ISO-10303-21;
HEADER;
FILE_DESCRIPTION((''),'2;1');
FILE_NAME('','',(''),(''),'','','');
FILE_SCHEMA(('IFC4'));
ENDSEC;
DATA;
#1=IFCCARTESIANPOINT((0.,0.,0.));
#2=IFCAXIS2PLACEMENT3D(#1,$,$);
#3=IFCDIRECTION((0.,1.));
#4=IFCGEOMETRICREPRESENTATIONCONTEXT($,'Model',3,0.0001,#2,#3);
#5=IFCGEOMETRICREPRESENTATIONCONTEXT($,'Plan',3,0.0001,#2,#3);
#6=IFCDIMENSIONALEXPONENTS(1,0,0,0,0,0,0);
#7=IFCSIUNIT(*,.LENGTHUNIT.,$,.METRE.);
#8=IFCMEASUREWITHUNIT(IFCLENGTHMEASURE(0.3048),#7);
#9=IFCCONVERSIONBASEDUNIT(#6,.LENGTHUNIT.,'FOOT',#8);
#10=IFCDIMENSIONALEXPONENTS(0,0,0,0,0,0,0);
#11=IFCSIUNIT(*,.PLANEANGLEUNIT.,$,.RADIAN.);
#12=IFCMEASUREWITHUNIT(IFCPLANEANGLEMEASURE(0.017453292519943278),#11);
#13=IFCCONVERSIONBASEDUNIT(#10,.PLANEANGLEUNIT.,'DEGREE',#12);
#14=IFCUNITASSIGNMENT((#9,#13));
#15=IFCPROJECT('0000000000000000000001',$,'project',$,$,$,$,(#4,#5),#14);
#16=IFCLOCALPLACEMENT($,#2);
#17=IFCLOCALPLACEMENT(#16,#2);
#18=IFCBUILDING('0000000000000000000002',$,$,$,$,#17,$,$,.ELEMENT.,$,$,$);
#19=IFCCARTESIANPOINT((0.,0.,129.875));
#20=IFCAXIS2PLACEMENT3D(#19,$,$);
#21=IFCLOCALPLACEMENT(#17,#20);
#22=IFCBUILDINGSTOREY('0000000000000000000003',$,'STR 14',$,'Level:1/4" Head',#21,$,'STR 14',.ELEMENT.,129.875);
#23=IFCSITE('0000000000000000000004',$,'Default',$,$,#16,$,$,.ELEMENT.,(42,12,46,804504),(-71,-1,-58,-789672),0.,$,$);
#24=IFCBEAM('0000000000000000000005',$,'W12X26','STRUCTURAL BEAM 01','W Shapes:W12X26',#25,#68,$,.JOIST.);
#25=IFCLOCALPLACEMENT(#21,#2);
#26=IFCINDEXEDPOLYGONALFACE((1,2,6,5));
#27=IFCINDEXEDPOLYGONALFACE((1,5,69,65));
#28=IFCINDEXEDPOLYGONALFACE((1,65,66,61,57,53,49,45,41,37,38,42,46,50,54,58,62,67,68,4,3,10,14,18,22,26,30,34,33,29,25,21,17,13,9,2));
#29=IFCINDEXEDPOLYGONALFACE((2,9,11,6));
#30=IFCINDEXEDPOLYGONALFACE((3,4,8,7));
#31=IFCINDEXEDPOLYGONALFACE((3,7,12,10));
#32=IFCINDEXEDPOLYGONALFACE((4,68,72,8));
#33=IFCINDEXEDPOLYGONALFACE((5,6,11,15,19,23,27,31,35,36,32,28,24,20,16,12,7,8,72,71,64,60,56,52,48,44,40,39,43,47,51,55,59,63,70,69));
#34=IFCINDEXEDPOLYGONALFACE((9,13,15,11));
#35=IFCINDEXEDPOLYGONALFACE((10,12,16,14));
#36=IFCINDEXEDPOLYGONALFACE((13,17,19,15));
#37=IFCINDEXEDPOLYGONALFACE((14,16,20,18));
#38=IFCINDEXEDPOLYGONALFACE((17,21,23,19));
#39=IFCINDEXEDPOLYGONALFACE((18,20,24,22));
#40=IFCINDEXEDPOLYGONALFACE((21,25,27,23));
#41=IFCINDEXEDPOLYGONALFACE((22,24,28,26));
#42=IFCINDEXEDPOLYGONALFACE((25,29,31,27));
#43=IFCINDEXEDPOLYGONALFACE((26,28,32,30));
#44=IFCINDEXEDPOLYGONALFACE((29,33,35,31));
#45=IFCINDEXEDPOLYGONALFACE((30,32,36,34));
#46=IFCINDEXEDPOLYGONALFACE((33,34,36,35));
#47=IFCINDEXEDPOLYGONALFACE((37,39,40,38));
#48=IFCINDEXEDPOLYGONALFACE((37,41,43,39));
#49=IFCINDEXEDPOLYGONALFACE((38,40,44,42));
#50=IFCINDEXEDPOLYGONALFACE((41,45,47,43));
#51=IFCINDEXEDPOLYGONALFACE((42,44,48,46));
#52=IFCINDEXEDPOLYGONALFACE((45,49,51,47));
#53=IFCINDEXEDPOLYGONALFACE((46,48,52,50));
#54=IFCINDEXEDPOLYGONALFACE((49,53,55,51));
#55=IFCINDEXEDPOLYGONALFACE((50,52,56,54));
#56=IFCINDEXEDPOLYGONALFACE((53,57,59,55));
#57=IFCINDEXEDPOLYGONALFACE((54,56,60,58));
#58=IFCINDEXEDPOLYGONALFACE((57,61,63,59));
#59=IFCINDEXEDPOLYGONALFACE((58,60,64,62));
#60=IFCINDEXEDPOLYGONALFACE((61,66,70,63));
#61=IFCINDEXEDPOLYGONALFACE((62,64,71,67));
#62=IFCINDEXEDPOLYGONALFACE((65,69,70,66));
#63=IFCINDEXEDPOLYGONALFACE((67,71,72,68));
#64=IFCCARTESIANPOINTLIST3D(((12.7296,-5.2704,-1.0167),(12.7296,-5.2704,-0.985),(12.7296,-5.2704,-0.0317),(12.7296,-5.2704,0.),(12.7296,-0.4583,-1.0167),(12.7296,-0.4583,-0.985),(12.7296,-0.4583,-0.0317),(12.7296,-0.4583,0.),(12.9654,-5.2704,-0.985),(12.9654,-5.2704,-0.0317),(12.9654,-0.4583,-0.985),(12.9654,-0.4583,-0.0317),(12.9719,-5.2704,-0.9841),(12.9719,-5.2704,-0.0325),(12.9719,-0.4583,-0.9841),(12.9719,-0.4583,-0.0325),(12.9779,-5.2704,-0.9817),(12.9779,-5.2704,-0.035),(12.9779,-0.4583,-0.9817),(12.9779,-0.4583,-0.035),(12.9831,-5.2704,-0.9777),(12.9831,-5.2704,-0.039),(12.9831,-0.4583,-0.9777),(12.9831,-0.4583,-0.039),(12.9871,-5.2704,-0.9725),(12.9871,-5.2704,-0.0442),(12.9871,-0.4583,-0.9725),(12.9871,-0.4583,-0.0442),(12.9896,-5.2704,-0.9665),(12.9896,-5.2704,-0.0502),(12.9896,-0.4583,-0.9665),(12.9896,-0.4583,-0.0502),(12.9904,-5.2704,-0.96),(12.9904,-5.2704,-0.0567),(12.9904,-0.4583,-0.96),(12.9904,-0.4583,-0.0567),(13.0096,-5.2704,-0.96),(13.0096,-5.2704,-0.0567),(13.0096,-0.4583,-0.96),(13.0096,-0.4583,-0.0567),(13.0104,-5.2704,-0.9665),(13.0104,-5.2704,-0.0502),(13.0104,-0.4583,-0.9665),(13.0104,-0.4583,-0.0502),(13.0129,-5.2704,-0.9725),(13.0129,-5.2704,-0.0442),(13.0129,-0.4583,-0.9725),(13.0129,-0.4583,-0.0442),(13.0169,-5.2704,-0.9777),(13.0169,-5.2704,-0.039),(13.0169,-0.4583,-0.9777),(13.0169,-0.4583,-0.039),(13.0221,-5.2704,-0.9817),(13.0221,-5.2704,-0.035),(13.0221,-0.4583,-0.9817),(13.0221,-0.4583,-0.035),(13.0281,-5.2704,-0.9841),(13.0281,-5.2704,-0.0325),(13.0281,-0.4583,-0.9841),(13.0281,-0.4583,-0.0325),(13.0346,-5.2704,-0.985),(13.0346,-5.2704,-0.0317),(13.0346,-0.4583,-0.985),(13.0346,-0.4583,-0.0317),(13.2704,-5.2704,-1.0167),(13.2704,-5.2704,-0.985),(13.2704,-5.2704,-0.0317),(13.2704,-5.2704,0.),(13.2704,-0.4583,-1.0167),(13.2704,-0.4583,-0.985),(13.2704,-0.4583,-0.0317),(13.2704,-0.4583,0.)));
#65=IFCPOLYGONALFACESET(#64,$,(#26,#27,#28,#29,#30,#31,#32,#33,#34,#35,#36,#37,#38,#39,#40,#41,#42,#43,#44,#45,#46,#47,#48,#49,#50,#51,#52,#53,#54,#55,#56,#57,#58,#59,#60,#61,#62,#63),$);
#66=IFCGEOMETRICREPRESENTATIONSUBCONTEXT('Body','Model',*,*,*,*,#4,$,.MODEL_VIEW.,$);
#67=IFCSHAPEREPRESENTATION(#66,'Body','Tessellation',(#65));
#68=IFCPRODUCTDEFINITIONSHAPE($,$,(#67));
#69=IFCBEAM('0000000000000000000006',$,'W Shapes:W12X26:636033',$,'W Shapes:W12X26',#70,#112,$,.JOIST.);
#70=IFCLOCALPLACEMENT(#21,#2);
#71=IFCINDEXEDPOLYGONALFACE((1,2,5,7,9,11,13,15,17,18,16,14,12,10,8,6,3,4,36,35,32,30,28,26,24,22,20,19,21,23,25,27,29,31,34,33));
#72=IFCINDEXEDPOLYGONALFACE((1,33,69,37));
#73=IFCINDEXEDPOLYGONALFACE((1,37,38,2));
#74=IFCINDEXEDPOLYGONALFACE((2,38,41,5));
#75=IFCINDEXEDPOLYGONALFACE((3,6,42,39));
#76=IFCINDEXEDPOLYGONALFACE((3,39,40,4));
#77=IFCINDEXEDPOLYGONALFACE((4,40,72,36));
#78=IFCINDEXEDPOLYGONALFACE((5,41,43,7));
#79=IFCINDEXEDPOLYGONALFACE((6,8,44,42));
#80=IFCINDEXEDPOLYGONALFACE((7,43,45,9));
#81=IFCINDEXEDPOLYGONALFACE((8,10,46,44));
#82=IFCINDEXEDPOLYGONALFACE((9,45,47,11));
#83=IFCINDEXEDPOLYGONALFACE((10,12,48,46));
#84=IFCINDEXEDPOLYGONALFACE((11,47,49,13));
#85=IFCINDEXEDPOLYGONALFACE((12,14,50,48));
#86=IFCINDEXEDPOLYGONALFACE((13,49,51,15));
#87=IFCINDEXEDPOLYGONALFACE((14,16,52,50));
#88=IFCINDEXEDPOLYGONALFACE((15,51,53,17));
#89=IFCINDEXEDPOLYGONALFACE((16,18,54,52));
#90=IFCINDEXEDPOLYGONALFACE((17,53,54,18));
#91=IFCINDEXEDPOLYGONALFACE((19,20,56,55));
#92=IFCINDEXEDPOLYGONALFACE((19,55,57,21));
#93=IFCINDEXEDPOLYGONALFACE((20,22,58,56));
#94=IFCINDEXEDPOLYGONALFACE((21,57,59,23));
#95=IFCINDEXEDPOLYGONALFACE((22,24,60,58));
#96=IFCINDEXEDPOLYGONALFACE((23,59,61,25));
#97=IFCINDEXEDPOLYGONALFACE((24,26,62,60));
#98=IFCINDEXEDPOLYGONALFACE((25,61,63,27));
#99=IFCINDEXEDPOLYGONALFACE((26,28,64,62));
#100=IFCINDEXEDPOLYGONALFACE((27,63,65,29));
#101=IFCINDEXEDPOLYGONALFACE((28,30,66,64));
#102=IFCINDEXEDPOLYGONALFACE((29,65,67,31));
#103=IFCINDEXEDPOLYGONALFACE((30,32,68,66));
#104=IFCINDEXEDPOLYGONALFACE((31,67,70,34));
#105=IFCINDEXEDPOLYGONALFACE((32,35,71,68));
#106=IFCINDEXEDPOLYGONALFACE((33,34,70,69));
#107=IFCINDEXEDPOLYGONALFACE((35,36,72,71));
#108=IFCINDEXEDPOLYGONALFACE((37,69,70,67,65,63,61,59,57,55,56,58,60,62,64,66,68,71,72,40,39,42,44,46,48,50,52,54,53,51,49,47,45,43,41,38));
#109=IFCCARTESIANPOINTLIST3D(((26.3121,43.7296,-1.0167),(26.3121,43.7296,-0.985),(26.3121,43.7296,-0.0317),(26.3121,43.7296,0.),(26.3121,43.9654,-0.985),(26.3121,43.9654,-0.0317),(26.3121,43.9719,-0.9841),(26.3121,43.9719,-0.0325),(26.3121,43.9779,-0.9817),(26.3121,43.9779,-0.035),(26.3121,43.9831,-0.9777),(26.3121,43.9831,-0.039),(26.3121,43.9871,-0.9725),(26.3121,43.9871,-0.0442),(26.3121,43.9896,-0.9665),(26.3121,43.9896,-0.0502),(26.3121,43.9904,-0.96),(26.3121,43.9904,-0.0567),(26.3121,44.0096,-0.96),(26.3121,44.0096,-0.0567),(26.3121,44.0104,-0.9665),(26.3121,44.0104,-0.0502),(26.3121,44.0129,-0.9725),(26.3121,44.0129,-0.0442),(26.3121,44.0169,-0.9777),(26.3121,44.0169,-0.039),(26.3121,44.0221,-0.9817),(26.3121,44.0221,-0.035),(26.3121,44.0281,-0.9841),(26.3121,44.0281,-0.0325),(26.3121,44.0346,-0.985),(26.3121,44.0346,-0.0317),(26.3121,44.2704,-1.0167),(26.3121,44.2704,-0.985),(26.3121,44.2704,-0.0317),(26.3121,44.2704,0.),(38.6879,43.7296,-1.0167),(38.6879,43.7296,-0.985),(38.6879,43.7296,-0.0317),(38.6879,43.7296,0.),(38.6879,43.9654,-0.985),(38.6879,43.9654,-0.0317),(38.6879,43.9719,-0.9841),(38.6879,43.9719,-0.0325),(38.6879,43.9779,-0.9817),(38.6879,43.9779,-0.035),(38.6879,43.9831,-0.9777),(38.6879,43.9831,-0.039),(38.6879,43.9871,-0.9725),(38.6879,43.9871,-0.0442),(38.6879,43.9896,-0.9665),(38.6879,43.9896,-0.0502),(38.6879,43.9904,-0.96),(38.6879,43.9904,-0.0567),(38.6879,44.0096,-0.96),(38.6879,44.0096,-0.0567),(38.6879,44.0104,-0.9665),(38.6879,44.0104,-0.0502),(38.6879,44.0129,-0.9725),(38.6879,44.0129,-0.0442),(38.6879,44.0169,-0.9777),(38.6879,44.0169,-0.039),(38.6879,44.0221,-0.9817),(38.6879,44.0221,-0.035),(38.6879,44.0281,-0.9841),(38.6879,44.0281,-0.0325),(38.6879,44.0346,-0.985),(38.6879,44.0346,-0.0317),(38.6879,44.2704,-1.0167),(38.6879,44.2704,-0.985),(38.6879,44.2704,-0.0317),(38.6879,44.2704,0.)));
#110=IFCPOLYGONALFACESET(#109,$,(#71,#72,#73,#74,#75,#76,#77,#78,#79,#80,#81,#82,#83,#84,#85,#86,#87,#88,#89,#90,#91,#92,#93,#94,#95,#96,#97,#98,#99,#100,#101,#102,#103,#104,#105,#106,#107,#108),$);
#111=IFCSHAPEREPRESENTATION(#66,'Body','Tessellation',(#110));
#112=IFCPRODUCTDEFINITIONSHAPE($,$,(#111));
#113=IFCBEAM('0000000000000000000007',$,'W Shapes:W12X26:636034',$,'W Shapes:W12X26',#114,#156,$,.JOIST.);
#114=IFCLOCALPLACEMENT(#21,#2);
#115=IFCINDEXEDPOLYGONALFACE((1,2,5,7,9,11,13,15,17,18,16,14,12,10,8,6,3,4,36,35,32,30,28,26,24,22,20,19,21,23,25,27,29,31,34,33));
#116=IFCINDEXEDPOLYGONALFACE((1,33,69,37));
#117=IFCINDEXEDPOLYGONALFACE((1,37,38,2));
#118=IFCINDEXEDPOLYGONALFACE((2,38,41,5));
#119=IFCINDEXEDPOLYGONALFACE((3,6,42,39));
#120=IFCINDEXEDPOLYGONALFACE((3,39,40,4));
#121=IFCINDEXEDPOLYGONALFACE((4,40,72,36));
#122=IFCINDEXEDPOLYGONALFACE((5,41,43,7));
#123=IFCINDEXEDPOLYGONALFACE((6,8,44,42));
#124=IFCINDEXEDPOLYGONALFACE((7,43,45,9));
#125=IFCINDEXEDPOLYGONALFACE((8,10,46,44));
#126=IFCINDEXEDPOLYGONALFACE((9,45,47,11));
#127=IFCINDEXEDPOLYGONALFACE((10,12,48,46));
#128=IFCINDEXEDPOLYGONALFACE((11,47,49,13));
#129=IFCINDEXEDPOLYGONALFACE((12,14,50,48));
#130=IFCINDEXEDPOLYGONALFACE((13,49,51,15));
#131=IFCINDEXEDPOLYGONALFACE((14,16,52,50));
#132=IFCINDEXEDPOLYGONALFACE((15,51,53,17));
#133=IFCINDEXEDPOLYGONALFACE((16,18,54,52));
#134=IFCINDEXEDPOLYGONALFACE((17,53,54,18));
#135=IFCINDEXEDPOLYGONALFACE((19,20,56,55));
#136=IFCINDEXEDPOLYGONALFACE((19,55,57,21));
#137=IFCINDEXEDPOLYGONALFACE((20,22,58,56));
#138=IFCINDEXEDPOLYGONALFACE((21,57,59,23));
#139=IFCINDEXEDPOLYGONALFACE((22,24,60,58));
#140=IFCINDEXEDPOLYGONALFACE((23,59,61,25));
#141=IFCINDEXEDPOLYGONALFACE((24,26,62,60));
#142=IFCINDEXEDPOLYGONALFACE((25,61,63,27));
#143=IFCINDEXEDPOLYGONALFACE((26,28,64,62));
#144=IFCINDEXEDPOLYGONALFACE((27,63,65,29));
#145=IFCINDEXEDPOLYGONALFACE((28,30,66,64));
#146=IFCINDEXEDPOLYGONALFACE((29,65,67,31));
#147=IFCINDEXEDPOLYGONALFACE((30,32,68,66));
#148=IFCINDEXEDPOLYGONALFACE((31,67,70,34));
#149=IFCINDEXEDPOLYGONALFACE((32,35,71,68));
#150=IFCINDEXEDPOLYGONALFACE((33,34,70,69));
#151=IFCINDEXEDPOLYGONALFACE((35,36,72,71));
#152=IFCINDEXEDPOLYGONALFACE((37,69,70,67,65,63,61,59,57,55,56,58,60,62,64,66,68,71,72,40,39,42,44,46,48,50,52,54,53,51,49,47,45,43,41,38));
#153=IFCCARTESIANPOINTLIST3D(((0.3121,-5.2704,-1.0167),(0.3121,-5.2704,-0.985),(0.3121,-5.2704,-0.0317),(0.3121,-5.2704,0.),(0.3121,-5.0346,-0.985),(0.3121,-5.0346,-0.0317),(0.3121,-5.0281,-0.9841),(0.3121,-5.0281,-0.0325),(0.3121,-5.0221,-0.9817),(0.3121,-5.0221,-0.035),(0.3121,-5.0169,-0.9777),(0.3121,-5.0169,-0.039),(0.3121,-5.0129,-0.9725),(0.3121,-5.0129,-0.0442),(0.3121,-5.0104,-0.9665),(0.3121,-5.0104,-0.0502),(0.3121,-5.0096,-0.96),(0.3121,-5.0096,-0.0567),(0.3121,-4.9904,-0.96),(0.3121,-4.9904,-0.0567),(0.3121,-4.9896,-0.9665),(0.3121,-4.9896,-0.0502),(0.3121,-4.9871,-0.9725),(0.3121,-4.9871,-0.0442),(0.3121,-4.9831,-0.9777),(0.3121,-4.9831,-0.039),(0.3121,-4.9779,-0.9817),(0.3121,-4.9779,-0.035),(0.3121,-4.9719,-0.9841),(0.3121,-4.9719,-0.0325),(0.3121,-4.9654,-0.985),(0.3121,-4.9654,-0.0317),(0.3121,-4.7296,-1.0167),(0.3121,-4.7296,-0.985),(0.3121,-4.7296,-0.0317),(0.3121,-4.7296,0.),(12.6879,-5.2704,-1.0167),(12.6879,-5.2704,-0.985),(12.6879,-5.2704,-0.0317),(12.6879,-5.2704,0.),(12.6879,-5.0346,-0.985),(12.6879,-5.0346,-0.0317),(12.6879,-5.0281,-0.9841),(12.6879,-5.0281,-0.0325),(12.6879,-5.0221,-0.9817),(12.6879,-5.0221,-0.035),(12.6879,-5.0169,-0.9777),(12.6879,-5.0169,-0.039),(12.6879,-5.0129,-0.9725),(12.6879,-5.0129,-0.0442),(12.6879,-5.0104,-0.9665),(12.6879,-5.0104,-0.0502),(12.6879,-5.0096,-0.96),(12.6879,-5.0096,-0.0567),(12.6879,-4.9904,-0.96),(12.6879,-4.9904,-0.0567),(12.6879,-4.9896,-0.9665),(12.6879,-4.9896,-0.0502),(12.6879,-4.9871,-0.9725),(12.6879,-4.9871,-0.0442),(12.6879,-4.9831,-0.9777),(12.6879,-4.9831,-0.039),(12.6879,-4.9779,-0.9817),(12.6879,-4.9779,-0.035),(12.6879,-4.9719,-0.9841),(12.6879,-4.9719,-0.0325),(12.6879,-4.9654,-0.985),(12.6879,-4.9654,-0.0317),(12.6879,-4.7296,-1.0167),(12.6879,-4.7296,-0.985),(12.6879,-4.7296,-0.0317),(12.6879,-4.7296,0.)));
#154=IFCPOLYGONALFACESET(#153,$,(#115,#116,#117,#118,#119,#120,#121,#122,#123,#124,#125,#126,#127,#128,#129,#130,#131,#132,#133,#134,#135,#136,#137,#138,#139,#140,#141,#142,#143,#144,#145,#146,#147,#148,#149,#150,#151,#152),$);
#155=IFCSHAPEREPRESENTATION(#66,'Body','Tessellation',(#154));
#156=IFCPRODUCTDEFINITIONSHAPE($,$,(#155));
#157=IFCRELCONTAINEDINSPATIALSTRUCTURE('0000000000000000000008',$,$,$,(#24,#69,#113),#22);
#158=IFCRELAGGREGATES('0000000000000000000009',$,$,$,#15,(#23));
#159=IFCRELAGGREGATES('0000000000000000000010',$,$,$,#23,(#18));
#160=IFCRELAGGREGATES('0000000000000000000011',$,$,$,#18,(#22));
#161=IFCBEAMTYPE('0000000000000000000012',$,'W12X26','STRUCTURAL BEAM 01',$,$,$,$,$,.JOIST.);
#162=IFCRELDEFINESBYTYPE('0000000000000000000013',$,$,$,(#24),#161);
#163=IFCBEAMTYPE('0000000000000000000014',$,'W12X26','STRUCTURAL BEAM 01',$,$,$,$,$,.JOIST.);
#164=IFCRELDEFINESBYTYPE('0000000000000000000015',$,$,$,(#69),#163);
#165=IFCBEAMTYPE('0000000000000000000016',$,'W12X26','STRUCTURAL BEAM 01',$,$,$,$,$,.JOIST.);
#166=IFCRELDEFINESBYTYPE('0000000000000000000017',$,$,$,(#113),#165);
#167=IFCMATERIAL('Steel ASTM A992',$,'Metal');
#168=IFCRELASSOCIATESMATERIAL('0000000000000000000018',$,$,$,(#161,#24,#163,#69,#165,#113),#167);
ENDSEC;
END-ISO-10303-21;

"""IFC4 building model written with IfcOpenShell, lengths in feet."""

from ifc_helpers import new_model, entity, si_unit, converted_unit, direction, frame, origin, place, context, subcontext, project, spatial, line, arc, indexed_curve, outline, extrude, source, transform, mapped, material, type_object, type_shapes, element, save


model = new_model("IFC4")

# Units and contexts
model_context = context("Model", 3, precision=0.0001, world=origin(), true_north=direction((0.0, 1.0)))
plan_context = context("Plan", 3, precision=0.0001, world=origin(), true_north=direction((0.0, 1.0)))
body_context = subcontext(model_context, "Body", "Model", "MODEL_VIEW")
ifc_project = project(units=[converted_unit("LENGTHUNIT", "FOOT", entity("IfcLengthMeasure", 0.3048), si_unit("LENGTHUNIT", "METRE"), dimensions=[1, 0, 0, 0, 0, 0, 0]), converted_unit("PLANEANGLEUNIT", "DEGREE", entity("IfcPlaneAngleMeasure", 0.017453292519943278), si_unit("PLANEANGLEUNIT", "RADIAN"), dimensions=[0, 0, 0, 0, 0, 0, 0])], contexts=[model_context, plan_context])

# Site, building, storey
site_placement = place(None, origin())
site = spatial("IfcSite", under=ifc_project, at=site_placement, Name="Default", CompositionType="ELEMENT", RefLatitude=(42, 12, 46, 804504), RefLongitude=(-71, -1, -58, -789672), RefElevation=0.0)
building_placement = place(site_placement, origin())
building = spatial("IfcBuilding", under=site, at=building_placement, CompositionType="ELEMENT")
storey_placement = place(building_placement, frame((0.0, 0.0, 129.875)))
storey = spatial("IfcBuildingStorey", under=building, at=storey_placement, Name="STR 14", ObjectType="Level:1/4\" Head", LongName="STR 14", CompositionType="ELEMENT", Elevation=129.875)

# Shared definitions
ifc_material = material(Name="Steel ASTM A992", Category="Metal")

# Beams
beam_type_1 = type_object("IfcBeamType", Name="W12X26", Description="STRUCTURAL BEAM 01", PredefinedType="JOIST", material=ifc_material)
shared_shape_1 = source(origin(), body_context, "Body", "SweptSolid", [
    extrude(outline(indexed_curve([(-0.2704, -0.5083), (0.2704, -0.5083), (0.2704, -0.4767), (0.0346, -0.4767), (0.0169, -0.4693), (0.0096, -0.4517), (0.0096, 0.4517), (0.0169, 0.4693), (0.0346, 0.4767), (0.2704, 0.4767), (0.2704, 0.5083), (-0.2704, 0.5083), (-0.2704, 0.4767), (-0.0346, 0.4767), (-0.0169, 0.4693), (-0.0096, 0.4517), (-0.0096, -0.4517), (-0.0169, -0.4693), (-0.0346, -0.4767), (-0.2704, -0.4767)], segments=[line(1, 2, 3, 4), arc(4, 5, 6), line(6, 7), arc(7, 8, 9), line(9, 10, 11, 12, 13, 14), arc(14, 15, 16), line(16, 17), arc(17, 18, 19), line(19, 20, 1)], self_intersect=False)), frame((13.0, -0.4583, 129.3667), z_axis=(0.0, -1.0, 0.0), x_axis=(-1.0, 0.0, 0.0)), (0.0, 0.0, 1.0), 4.8121),
])
type_shapes(beam_type_1, [shared_shape_1])
beam_1_placement = place(storey_placement, frame((0.0, 0.0, -129.875)))
element("IfcBeam", 1, at=beam_1_placement, inside=storey, type_object=beam_type_1, material=ifc_material, Name="W12X26", Description="STRUCTURAL BEAM 01", ObjectType="W Shapes:W12X26", PredefinedType="JOIST", context=body_context, shape_type="MappedRepresentation", body=[
    mapped(shared_shape_1, transform((0.0, 0.0, 0.0), scale=1.0)),
])
beam_type_2 = type_object("IfcBeamType", Name="W12X26", Description="STRUCTURAL BEAM 01", PredefinedType="JOIST", material=ifc_material)
shared_shape_2 = source(origin(), body_context, "Body", "SweptSolid", [
    extrude(outline(indexed_curve([(-0.5083, -0.2704), (-0.4767, -0.2704), (-0.4767, -0.0346), (-0.4693, -0.0169), (-0.4517, -0.0096), (0.4517, -0.0096), (0.4693, -0.0169), (0.4767, -0.0346), (0.4767, -0.2704), (0.5083, -0.2704), (0.5083, 0.2704), (0.4767, 0.2704), (0.4767, 0.0346), (0.4693, 0.0169), (0.4517, 0.0096), (-0.4517, 0.0096), (-0.4693, 0.0169), (-0.4767, 0.0346), (-0.4767, 0.2704), (-0.5083, 0.2704)], segments=[line(1, 2, 3), arc(3, 4, 5), line(5, 6), arc(6, 7, 8), line(8, 9, 10, 11, 12, 13), arc(13, 14, 15), line(15, 16), arc(16, 17, 18), line(18, 19, 20, 1)], self_intersect=False)), frame((26.3121, 44.0, 129.3667), z_axis=(1.0, 0.0, 0.0), x_axis=(0.0, 0.0, -1.0)), (0.0, 0.0, 1.0), 12.3758),
])
type_shapes(beam_type_2, [shared_shape_2])
beam_2_placement = place(storey_placement, frame((0.0, 0.0, -129.875)))
element("IfcBeam", 2, at=beam_2_placement, inside=storey, type_object=beam_type_2, material=ifc_material, Name="W Shapes:W12X26:636033", ObjectType="W Shapes:W12X26", PredefinedType="JOIST", context=body_context, shape_type="MappedRepresentation", body=[
    mapped(shared_shape_2, transform((0.0, 0.0, 0.0), scale=1.0)),
])
beam_type_3 = type_object("IfcBeamType", Name="W12X26", Description="STRUCTURAL BEAM 01", PredefinedType="JOIST", material=ifc_material)
shared_shape_3 = source(origin(), body_context, "Body", "SweptSolid", [
    extrude(outline(indexed_curve([(-0.5083, -0.2704), (-0.4767, -0.2704), (-0.4767, -0.0346), (-0.4693, -0.0169), (-0.4517, -0.0096), (0.4517, -0.0096), (0.4693, -0.0169), (0.4767, -0.0346), (0.4767, -0.2704), (0.5083, -0.2704), (0.5083, 0.2704), (0.4767, 0.2704), (0.4767, 0.0346), (0.4693, 0.0169), (0.4517, 0.0096), (-0.4517, 0.0096), (-0.4693, 0.0169), (-0.4767, 0.0346), (-0.4767, 0.2704), (-0.5083, 0.2704)], segments=[line(1, 2, 3), arc(3, 4, 5), line(5, 6), arc(6, 7, 8), line(8, 9, 10, 11, 12, 13), arc(13, 14, 15), line(15, 16), arc(16, 17, 18), line(18, 19, 20, 1)], self_intersect=False)), frame((0.3121, -5.0, 129.3667), z_axis=(1.0, 0.0, 0.0), x_axis=(0.0, 0.0, -1.0)), (0.0, 0.0, 1.0), 12.3758),
])
type_shapes(beam_type_3, [shared_shape_3])
beam_3_placement = place(storey_placement, frame((0.0, 0.0, -129.875)))
element("IfcBeam", 3, at=beam_3_placement, inside=storey, type_object=beam_type_3, material=ifc_material, Name="W Shapes:W12X26:636034", ObjectType="W Shapes:W12X26", PredefinedType="JOIST", context=body_context, shape_type="MappedRepresentation", body=[
    mapped(shared_shape_3, transform((0.0, 0.0, 0.0), scale=1.0)),
])

save(model, "model.ifc")
